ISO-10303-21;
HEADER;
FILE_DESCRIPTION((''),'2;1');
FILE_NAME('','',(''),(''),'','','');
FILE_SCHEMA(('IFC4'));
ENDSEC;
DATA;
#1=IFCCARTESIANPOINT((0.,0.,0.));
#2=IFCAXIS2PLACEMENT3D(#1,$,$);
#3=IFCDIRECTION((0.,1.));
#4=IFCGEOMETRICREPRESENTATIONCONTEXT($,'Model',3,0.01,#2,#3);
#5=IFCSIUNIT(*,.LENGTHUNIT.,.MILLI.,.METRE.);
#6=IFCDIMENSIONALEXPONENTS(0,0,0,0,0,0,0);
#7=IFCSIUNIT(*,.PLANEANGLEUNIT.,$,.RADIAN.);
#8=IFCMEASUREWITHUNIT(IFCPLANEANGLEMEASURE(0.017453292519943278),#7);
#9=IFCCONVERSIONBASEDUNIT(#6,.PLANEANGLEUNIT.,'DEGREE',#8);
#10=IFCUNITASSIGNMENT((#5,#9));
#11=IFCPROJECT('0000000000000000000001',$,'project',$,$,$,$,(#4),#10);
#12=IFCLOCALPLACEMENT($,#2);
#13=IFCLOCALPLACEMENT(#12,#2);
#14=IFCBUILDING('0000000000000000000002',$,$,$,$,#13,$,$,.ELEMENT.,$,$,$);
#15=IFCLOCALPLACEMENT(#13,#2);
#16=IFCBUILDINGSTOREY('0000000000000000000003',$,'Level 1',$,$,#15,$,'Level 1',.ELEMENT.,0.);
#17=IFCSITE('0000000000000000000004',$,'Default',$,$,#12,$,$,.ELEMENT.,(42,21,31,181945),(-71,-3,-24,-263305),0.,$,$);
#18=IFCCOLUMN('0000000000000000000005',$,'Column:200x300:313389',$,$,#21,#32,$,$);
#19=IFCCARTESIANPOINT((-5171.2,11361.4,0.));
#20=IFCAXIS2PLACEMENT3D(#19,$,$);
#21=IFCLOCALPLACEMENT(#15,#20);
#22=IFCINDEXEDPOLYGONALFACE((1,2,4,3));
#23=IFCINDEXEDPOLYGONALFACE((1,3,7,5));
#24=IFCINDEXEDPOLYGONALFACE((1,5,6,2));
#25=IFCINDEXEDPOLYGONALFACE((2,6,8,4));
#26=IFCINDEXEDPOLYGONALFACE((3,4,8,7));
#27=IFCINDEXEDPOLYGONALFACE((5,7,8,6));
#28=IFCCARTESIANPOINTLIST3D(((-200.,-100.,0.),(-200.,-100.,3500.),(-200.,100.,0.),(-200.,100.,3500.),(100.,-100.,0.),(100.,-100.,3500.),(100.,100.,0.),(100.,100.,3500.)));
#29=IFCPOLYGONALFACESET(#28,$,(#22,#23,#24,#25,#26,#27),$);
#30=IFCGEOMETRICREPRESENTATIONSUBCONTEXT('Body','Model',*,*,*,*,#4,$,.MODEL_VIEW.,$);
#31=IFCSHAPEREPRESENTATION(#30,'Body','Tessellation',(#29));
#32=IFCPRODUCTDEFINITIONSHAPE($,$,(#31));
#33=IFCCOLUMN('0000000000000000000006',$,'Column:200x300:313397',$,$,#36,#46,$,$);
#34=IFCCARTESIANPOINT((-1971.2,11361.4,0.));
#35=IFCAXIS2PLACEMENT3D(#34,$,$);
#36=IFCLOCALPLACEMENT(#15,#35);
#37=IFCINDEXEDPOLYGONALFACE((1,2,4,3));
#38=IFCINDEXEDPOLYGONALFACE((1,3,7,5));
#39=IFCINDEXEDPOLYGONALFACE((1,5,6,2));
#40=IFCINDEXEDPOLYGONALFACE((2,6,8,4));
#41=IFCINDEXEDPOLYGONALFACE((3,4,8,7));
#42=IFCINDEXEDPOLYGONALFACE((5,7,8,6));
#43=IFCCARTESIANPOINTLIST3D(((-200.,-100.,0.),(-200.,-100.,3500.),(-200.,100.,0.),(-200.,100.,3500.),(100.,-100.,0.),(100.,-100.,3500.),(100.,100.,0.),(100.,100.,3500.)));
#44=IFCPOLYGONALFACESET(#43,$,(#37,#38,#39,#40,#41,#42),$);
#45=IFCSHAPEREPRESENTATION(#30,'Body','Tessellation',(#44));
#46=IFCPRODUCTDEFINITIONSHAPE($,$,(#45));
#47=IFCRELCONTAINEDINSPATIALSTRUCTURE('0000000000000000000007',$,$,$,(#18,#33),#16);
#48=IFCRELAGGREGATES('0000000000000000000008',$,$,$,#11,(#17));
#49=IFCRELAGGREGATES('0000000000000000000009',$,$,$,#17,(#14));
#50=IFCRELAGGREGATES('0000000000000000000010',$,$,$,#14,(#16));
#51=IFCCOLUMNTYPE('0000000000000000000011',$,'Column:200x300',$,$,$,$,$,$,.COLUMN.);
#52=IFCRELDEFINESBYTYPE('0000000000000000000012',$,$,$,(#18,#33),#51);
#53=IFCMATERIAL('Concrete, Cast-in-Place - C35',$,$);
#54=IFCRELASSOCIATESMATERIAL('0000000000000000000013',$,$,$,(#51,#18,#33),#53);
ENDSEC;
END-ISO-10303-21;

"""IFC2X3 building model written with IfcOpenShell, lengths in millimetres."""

from ifc_helpers import new_model, entity, si_unit, converted_unit, direction, frame, origin, origin_2d_with_axis, place, context, subcontext, project, spatial, rectangle, extrude, source, transform, mapped, material, type_object, type_shapes, element, save


model = new_model("IFC2X3")

# Units and contexts
model_context = context("Model", 3, precision=0.01, world=origin(), true_north=direction((0.0, 1.0)))
body_context = subcontext(model_context, "Body", "Model", "MODEL_VIEW")
ifc_project = project(units=[si_unit("LENGTHUNIT", "METRE", prefix="MILLI"), converted_unit("PLANEANGLEUNIT", "DEGREE", entity("IfcPlaneAngleMeasure", 0.017453292519943278), si_unit("PLANEANGLEUNIT", "RADIAN"), dimensions=[0, 0, 0, 0, 0, 0, 0])], contexts=[model_context])

# Site, building, storey
site_placement = place(None, origin())
site = spatial("IfcSite", under=ifc_project, at=site_placement, Name="Default", CompositionType="ELEMENT", RefLatitude=(42, 21, 31, 181945), RefLongitude=(-71, -3, -24, -263305), RefElevation=0.0)
building_placement = place(site_placement, origin())
building = spatial("IfcBuilding", under=site, at=building_placement, CompositionType="ELEMENT")
storey_placement = place(building_placement, origin())
storey = spatial("IfcBuildingStorey", under=building, at=storey_placement, Name="Level 1", LongName="Level 1", CompositionType="ELEMENT", Elevation=0.0)

# Columns
ifc_material_1 = material(Name="Concrete, Cast-in-Place - C35")
column_type_1 = type_object("IfcColumnType", Name="Column:200x300", PredefinedType="COLUMN", material=ifc_material_1)
shared_shape_1 = source(origin(), body_context, "Body", "SweptSolid", [
    extrude(rectangle(XDim=300.0, YDim=200.0, at=origin_2d_with_axis()), frame((-50.0, 0.0, 0.0), z_axis=(0.0, 0.0, 1.0), x_axis=(-1.0, 0.0, 0.0)), (0.0, 0.0, 1.0), 3500.0),
])
type_shapes(column_type_1, [shared_shape_1])
for number, where, name in (
    (1, (-5171.2, 11361.4, 0.0), "Column:200x300:313389"),
    (2, (-1971.2, 11361.4, 0.0), "Column:200x300:313397"),
):
    element("IfcColumn", number, at=place(storey_placement, frame(where)), inside=storey, type_object=column_type_1, material=ifc_material_1, Name=name, context=body_context, shape_type="MappedRepresentation", body=[
        mapped(shared_shape_1, transform((0.0, 0.0, 0.0), scale=1.0)),
    ])

save(model, "model.ifc")
